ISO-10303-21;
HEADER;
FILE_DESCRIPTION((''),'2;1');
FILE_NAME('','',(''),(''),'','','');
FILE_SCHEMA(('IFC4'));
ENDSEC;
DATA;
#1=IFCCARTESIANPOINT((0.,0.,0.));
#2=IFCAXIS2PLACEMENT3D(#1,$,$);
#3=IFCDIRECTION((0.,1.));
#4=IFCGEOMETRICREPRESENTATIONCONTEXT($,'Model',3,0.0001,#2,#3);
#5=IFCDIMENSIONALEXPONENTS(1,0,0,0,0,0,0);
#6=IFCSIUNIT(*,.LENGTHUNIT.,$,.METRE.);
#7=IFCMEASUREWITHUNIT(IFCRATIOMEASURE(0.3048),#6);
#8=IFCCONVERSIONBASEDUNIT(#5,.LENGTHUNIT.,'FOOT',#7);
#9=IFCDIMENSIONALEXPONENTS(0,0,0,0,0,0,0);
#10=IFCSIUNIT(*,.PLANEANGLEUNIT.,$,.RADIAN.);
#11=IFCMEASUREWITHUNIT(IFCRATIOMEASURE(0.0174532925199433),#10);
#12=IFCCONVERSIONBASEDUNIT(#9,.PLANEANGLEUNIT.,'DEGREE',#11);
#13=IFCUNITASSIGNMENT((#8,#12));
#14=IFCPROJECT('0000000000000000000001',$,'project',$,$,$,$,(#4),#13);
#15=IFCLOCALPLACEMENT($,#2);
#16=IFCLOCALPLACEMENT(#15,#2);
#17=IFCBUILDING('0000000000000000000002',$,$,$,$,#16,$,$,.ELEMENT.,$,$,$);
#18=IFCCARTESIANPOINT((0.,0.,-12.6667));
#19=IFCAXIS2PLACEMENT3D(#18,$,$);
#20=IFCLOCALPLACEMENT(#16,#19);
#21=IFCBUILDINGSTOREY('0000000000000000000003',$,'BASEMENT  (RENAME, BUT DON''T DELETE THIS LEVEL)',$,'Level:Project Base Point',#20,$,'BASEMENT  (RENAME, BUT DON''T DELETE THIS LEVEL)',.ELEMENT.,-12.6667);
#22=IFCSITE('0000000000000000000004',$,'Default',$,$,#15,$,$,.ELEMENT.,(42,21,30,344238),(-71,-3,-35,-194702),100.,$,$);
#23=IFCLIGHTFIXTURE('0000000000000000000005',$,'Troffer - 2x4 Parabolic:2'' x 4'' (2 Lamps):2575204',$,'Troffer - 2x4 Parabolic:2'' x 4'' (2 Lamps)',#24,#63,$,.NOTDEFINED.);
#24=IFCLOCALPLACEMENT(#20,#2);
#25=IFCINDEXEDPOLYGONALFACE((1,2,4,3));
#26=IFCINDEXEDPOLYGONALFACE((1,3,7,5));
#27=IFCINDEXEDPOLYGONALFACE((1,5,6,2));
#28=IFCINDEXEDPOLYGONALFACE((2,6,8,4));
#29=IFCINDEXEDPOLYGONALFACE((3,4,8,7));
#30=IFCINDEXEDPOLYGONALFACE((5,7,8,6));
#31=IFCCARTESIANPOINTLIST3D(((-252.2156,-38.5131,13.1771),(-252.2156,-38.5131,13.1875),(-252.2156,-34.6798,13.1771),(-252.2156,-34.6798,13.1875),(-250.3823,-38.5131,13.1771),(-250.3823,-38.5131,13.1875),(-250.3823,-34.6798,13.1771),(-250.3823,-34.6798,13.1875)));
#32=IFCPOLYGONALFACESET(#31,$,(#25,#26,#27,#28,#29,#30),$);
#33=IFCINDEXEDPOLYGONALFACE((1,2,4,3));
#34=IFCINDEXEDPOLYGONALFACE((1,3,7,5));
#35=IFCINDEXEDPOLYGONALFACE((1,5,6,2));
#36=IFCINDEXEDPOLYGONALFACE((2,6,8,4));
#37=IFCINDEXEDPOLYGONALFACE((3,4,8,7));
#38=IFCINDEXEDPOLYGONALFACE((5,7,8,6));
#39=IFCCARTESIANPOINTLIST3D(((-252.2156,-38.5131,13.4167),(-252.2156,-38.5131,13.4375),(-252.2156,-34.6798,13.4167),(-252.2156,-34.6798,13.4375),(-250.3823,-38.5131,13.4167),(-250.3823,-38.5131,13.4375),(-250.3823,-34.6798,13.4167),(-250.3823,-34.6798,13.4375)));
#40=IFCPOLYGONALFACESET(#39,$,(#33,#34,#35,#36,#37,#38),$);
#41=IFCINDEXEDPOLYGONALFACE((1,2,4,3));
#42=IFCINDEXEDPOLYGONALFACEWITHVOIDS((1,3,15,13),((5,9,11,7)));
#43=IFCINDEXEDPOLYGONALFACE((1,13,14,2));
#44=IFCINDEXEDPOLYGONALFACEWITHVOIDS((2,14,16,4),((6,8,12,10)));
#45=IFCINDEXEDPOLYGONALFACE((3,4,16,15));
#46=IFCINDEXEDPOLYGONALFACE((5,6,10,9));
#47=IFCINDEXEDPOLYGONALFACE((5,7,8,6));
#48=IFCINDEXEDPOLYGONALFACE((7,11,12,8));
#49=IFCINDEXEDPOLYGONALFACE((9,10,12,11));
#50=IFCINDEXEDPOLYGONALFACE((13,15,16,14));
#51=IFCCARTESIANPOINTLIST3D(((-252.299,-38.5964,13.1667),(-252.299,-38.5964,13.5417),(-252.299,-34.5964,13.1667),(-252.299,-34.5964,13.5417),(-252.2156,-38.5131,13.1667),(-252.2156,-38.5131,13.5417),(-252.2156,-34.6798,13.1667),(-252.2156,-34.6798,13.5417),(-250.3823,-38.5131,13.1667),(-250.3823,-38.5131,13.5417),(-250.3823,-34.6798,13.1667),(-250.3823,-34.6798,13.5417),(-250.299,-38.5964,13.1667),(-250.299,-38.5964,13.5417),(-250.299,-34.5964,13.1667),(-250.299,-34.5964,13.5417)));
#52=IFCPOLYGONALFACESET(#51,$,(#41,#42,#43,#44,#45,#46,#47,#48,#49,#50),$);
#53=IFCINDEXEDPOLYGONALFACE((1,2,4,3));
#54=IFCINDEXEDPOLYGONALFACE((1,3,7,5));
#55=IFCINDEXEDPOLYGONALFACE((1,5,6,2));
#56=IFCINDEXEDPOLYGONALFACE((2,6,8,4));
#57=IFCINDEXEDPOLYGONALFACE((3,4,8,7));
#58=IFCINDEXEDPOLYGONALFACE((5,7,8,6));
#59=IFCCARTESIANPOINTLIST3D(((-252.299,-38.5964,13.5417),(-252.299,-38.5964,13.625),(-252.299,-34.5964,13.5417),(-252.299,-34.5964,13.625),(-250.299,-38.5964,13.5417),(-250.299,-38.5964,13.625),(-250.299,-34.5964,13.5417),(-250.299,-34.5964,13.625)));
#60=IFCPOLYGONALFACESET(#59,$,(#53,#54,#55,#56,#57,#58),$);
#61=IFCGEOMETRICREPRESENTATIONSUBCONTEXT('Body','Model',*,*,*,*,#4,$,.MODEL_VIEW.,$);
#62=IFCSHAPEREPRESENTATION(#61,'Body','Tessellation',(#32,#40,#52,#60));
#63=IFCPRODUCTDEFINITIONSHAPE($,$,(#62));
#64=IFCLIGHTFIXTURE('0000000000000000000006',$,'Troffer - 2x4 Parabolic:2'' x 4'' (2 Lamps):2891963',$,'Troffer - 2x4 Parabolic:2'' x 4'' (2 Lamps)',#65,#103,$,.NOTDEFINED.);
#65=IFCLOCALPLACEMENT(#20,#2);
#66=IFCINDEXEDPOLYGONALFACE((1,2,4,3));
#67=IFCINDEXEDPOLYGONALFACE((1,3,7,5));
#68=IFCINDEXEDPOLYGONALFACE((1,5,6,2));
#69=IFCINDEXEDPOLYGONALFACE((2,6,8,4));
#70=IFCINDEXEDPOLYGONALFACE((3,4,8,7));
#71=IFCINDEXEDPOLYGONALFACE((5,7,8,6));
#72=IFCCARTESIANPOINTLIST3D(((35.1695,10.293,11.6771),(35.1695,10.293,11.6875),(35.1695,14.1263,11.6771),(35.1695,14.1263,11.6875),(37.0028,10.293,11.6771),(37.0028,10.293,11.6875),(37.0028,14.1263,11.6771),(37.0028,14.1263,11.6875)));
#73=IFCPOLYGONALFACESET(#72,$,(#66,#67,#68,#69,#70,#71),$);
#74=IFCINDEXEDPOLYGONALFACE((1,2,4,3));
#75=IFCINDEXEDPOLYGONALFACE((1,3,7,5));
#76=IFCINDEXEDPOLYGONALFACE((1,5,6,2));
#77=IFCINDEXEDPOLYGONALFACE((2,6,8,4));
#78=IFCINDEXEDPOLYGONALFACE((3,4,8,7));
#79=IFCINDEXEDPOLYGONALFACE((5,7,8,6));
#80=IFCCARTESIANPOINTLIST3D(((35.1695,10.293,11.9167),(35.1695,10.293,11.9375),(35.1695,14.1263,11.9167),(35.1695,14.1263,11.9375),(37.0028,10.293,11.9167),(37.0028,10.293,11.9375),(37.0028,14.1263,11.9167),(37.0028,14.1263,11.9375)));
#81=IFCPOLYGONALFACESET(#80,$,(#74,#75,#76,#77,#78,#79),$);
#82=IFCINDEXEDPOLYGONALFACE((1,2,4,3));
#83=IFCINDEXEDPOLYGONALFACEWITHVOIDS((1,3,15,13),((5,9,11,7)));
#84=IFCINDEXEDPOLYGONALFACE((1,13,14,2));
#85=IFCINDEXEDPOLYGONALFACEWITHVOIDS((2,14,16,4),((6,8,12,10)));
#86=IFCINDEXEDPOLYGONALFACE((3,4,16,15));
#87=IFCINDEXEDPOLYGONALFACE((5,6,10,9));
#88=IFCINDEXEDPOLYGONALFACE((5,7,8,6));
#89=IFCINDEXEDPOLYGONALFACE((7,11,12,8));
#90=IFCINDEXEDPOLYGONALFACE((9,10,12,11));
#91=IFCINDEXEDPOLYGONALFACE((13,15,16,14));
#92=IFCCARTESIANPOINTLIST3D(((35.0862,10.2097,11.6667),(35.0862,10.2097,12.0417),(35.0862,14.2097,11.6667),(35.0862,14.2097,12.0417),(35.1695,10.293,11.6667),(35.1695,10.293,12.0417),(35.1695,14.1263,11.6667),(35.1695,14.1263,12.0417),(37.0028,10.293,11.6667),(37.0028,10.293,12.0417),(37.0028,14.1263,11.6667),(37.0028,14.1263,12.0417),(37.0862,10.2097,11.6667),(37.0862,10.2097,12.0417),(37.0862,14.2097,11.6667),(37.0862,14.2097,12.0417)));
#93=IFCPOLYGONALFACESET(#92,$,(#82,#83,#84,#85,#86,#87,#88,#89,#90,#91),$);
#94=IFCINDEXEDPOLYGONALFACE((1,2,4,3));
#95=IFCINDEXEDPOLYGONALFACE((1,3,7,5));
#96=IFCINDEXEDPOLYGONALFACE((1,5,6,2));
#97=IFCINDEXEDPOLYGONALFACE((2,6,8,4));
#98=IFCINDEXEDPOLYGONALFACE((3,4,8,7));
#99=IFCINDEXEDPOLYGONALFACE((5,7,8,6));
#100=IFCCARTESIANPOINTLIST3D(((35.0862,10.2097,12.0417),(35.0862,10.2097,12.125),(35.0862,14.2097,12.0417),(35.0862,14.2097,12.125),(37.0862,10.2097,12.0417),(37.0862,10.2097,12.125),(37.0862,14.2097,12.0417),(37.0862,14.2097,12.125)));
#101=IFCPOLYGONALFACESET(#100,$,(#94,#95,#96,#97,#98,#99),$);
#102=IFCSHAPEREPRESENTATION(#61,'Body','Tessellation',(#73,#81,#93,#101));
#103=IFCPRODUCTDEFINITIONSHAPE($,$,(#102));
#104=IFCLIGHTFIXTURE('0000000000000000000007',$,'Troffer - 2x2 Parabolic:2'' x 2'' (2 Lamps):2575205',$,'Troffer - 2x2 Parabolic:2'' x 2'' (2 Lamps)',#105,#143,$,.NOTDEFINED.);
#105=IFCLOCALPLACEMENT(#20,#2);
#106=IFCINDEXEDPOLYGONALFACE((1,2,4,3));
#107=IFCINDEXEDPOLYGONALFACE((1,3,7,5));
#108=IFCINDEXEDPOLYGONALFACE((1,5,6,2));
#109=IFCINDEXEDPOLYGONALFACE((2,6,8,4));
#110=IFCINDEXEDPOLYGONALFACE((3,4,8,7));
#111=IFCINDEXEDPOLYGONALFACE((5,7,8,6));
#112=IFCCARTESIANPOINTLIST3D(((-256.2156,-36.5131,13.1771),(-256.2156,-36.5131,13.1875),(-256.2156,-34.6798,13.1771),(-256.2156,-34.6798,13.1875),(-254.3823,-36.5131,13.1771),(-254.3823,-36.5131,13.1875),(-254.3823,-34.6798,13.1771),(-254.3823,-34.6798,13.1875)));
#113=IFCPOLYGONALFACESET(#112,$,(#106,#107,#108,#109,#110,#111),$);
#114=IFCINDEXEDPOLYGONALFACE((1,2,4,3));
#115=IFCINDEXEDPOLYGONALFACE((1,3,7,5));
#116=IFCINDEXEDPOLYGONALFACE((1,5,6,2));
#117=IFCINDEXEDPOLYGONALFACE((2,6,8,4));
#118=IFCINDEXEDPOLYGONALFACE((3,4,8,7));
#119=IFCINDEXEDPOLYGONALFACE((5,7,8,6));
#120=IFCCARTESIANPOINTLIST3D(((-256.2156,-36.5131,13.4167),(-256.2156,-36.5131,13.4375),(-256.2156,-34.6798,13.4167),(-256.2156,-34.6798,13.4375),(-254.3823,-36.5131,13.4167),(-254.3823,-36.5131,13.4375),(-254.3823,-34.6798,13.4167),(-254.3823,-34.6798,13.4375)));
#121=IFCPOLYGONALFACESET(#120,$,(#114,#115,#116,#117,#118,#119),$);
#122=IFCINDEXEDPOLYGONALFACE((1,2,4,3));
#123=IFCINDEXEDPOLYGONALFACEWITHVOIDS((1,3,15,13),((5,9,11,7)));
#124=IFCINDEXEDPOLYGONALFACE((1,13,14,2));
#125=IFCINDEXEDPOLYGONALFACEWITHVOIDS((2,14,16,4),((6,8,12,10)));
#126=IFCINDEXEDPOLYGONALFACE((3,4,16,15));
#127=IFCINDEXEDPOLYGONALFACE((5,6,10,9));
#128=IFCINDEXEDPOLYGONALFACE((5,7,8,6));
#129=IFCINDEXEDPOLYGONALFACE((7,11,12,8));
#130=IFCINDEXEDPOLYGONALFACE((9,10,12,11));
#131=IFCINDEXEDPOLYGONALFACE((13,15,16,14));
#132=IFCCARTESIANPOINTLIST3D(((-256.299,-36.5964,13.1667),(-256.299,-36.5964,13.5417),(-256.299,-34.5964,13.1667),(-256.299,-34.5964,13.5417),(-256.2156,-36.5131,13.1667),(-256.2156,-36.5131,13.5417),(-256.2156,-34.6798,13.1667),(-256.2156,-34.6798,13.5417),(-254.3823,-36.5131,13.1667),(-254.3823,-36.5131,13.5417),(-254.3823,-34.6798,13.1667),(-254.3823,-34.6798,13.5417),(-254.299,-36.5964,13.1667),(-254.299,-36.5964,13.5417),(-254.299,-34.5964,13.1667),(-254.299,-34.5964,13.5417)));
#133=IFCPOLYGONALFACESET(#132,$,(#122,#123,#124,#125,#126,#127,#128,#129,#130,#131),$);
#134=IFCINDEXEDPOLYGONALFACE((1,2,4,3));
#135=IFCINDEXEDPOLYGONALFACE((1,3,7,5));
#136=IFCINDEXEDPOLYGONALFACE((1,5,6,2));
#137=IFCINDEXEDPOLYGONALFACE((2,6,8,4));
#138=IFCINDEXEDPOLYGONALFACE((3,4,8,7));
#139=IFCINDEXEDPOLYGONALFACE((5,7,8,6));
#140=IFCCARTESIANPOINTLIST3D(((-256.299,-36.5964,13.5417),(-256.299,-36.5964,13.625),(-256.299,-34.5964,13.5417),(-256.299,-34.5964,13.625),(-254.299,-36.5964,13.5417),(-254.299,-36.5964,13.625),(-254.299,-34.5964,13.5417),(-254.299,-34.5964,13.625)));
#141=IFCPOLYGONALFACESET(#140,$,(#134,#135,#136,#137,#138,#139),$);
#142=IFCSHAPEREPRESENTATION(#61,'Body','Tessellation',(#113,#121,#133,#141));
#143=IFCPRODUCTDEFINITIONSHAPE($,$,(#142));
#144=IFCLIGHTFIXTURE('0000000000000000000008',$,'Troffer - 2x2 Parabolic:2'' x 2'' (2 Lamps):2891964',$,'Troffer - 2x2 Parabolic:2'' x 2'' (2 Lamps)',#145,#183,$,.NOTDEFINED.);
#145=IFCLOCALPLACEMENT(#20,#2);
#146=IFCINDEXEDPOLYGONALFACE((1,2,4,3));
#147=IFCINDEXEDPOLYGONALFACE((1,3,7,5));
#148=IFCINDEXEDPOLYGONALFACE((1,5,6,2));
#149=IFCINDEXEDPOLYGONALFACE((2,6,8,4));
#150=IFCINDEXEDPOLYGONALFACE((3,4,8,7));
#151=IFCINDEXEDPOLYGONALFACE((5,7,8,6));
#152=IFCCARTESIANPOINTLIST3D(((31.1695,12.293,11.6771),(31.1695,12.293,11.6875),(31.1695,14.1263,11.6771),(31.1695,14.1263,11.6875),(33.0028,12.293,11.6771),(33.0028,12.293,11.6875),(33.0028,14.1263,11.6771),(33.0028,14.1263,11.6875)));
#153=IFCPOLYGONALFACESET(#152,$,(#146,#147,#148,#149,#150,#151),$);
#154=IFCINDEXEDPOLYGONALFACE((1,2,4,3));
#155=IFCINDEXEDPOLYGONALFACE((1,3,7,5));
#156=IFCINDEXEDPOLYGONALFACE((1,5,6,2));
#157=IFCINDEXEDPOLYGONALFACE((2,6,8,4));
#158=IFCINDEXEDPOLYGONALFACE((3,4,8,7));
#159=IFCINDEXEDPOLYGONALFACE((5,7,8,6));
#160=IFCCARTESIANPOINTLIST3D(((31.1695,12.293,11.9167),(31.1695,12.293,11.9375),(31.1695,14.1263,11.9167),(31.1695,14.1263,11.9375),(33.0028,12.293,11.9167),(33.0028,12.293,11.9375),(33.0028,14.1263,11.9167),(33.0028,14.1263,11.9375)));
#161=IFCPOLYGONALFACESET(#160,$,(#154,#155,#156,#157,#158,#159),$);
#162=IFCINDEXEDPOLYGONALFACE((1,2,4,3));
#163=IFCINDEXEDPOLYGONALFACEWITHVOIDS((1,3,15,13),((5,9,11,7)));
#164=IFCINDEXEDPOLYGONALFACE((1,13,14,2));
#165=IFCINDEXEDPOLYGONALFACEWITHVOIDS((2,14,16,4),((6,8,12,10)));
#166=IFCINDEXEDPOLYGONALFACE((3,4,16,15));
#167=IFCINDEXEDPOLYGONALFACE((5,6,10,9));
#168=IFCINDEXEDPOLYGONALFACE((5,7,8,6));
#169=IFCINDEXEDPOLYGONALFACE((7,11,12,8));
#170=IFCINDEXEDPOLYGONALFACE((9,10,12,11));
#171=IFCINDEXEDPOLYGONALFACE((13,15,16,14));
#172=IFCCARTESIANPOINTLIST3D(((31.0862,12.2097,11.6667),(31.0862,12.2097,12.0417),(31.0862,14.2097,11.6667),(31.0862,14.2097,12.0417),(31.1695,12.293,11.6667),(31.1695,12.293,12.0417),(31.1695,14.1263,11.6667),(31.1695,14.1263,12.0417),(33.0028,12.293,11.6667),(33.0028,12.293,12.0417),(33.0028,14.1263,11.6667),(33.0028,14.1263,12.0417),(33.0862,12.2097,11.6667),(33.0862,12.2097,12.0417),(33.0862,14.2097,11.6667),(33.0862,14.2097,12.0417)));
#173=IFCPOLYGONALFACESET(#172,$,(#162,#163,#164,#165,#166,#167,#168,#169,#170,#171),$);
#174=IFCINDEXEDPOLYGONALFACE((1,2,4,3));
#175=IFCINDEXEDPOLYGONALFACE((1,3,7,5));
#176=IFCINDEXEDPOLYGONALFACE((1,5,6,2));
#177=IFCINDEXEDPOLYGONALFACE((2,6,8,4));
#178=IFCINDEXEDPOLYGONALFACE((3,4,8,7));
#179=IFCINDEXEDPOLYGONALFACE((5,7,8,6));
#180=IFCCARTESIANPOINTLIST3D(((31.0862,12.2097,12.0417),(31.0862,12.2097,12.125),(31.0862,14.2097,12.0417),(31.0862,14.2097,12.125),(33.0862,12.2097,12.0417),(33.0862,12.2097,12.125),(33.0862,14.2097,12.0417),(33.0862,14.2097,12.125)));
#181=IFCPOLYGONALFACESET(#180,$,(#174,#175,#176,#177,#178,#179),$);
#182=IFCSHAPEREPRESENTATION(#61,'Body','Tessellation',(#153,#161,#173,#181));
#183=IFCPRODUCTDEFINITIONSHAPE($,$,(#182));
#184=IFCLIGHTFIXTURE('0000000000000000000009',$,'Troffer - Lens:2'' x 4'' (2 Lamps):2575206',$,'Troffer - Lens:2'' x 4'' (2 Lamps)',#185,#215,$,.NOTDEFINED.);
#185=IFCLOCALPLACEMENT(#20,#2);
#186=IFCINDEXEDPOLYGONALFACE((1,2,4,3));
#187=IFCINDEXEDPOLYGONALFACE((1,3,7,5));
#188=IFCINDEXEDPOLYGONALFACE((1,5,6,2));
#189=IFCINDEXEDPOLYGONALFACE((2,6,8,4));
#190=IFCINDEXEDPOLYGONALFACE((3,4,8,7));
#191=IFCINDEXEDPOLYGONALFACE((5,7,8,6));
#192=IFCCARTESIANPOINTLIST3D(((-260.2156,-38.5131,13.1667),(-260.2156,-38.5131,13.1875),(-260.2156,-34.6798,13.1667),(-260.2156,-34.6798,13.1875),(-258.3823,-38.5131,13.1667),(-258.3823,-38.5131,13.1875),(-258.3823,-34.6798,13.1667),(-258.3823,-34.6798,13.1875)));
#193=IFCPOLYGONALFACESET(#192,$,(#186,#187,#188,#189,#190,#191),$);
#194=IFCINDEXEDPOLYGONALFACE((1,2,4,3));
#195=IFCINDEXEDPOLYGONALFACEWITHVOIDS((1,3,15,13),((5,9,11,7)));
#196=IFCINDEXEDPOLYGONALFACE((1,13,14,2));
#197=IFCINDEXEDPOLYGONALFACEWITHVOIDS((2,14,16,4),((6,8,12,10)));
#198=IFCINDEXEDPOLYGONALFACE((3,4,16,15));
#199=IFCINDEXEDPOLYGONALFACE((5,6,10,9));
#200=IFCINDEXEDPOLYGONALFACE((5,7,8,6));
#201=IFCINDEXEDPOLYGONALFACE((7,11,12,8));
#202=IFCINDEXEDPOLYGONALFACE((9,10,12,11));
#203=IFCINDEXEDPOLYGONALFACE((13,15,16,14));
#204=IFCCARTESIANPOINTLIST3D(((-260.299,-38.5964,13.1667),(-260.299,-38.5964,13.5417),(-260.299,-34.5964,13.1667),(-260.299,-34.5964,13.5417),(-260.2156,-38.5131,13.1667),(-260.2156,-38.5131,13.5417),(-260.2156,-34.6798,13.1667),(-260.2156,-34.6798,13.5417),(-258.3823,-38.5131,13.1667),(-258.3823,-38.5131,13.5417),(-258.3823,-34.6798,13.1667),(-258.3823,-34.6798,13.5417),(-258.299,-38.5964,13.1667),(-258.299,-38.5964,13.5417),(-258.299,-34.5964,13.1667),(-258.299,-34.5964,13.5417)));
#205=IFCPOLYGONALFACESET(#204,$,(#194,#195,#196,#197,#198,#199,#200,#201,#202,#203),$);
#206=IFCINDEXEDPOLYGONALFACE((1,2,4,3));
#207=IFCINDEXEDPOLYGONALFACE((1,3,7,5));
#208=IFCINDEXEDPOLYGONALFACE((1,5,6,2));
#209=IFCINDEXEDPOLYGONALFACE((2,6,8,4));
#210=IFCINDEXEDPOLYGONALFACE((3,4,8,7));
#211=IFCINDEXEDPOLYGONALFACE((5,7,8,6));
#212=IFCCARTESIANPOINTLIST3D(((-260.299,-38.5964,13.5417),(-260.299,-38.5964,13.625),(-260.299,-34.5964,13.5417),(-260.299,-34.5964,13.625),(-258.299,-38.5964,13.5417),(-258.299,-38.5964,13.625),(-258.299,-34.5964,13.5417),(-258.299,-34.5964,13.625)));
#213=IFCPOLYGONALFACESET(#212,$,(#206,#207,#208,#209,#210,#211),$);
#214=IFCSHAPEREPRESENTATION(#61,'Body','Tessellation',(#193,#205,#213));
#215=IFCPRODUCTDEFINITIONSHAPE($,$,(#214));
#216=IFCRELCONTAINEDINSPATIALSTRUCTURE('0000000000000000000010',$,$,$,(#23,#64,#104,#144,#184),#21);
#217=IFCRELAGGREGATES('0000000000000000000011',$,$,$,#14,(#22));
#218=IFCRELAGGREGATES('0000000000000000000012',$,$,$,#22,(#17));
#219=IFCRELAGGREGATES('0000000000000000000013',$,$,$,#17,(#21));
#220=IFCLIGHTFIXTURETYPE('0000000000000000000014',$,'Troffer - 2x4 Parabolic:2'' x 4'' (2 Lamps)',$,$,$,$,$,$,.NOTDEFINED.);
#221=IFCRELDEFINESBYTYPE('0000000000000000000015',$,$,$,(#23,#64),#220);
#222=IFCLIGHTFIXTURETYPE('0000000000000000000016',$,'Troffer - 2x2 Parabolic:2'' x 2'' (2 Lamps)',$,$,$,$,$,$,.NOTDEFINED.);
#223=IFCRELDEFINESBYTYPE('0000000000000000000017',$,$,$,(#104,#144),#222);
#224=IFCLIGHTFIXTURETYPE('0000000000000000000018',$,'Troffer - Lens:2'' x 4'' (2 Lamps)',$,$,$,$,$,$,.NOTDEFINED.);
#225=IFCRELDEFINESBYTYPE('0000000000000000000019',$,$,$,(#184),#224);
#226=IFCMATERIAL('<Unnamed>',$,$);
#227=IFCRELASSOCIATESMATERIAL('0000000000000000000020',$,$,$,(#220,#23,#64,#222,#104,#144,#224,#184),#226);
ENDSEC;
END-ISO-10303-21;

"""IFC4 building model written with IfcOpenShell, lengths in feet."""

from ifc_helpers import new_model, entity, si_unit, converted_unit, direction, frame, frame_2d, origin, origin_2d_with_axis, place, context, subcontext, project, spatial, polyline, rectangle, outline, extrude, source, transform, mapped, material, type_object, type_shapes, element, save


model = new_model("IFC4")

# Units and contexts
model_context = context("Model", 3, precision=0.0001, world=origin(), true_north=direction((0.0, 1.0)))
body_context = subcontext(model_context, "Body", "Model", "MODEL_VIEW")
ifc_project = project(units=[converted_unit("LENGTHUNIT", "FOOT", entity("IfcRatioMeasure", 0.3048), si_unit("LENGTHUNIT", "METRE"), dimensions=[1, 0, 0, 0, 0, 0, 0]), converted_unit("PLANEANGLEUNIT", "DEGREE", entity("IfcRatioMeasure", 0.0174532925199433), si_unit("PLANEANGLEUNIT", "RADIAN"), dimensions=[0, 0, 0, 0, 0, 0, 0])], contexts=[model_context])

# Site, building, storey
site_placement = place(None, origin())
site = spatial("IfcSite", under=ifc_project, at=site_placement, Name="Default", CompositionType="ELEMENT", RefLatitude=(42, 21, 30, 344238), RefLongitude=(-71, -3, -35, -194702), RefElevation=100.0)
building_placement = place(site_placement, origin())
building = spatial("IfcBuilding", under=site, at=building_placement, CompositionType="ELEMENT")
storey_placement = place(building_placement, frame((0.0, 0.0, -12.6667)))
storey = spatial("IfcBuildingStorey", under=building, at=storey_placement, Name="BASEMENT  (RENAME, BUT DON'T DELETE THIS LEVEL)", ObjectType="Level:Project Base Point", LongName="BASEMENT  (RENAME, BUT DON'T DELETE THIS LEVEL)", CompositionType="ELEMENT", Elevation=-12.6667)

# Light fixtures
ifc_material_1 = material(Name="<Unnamed>")
light_fixture_type_1 = type_object("IfcLightFixtureType", Name="Troffer - 2x4 Parabolic:2' x 4' (2 Lamps)", PredefinedType="NOTDEFINED", material=ifc_material_1)
shared_shape_1 = source(origin(), body_context, "Body", "SweptSolid", [
    extrude(rectangle(XDim=3.8333, YDim=1.8333, at=frame_2d((0.0, 0.0), x_axis=(1.0, 0.0))), frame((2.0, 1.0, 0.0104), z_axis=(0.0, 0.0, 1.0), x_axis=(-1.0, 0.0, 0.0)), (0.0, 0.0, 1.0), 0.0104),
    extrude(rectangle(XDim=3.8333, YDim=1.8333, at=origin_2d_with_axis()), frame((2.0, 1.0, 0.25), z_axis=(0.0, 0.0, 1.0), x_axis=(-1.0, 0.0, 0.0)), (0.0, 0.0, 1.0), 0.0208),
    extrude(outline(polyline([(-2.0, -1.0), (2.0, -1.0), (2.0, 1.0), (-2.0, 1.0), (-2.0, -1.0)]), holes=[polyline([(-1.9167, -0.9167), (-1.9167, 0.9167), (1.9167, 0.9167), (1.9167, -0.9167), (-1.9167, -0.9167)])]), frame((2.0, 1.0, 0.0), z_axis=(0.0, 0.0, 1.0), x_axis=(-1.0, 0.0, 0.0)), (0.0, 0.0, 1.0), 0.375),
    extrude(rectangle(XDim=4.0, YDim=2.0, at=frame_2d((0.0, 0.0), x_axis=(1.0, 0.0))), frame((2.0, 1.0, 0.375), z_axis=(0.0, 0.0, 1.0), x_axis=(-1.0, 0.0, 0.0)), (0.0, 0.0, 1.0), 0.0833),
])
type_shapes(light_fixture_type_1, [shared_shape_1])
for number, where, z_axis, x_axis, name in (
    (1, (-250.299, -38.5964, 13.1667), (0.0, 0.0, 1.0), (0.0, 1.0, 0.0), "Troffer - 2x4 Parabolic:2' x 4' (2 Lamps):2575204"),
    (2, (37.0862, 10.2097, 11.6667), (0.0, 0.0, 1.0), (0.0, 1.0, 0.0), "Troffer - 2x4 Parabolic:2' x 4' (2 Lamps):2891963"),
):
    element("IfcLightFixture", number, at=place(storey_placement, frame(where, z_axis=z_axis, x_axis=x_axis)), inside=storey, type_object=light_fixture_type_1, material=ifc_material_1, Name=name, ObjectType="Troffer - 2x4 Parabolic:2' x 4' (2 Lamps)", PredefinedType="NOTDEFINED", context=body_context, shape_type="MappedRepresentation", body=[
        mapped(shared_shape_1, transform((0.0, 0.0, 0.0), scale=1.0)),
    ])
light_fixture_type_2 = type_object("IfcLightFixtureType", Name="Troffer - 2x2 Parabolic:2' x 2' (2 Lamps)", PredefinedType="NOTDEFINED", material=ifc_material_1)
shared_shape_2 = source(origin(), body_context, "Body", "SweptSolid", [
    extrude(rectangle(XDim=1.8333, YDim=1.8333, at=origin_2d_with_axis()), frame((1.0, 1.0, 0.0104), z_axis=(0.0, 0.0, 1.0), x_axis=(-1.0, 0.0, 0.0)), (0.0, 0.0, 1.0), 0.0104),
    extrude(rectangle(XDim=1.8333, YDim=1.8333, at=origin_2d_with_axis()), frame((1.0, 1.0, 0.25), z_axis=(0.0, 0.0, 1.0), x_axis=(-1.0, 0.0, 0.0)), (0.0, 0.0, 1.0), 0.0208),
    extrude(outline(polyline([(-1.0, -1.0), (1.0, -1.0), (1.0, 1.0), (-1.0, 1.0), (-1.0, -1.0)]), holes=[polyline([(-0.9167, -0.9167), (-0.9167, 0.9167), (0.9167, 0.9167), (0.9167, -0.9167), (-0.9167, -0.9167)])]), frame((1.0, 1.0, 0.0), z_axis=(0.0, 0.0, 1.0), x_axis=(-1.0, 0.0, 0.0)), (0.0, 0.0, 1.0), 0.375),
    extrude(rectangle(XDim=2.0, YDim=2.0, at=origin_2d_with_axis()), frame((1.0, 1.0, 0.375), z_axis=(0.0, 0.0, 1.0), x_axis=(-1.0, 0.0, 0.0)), (0.0, 0.0, 1.0), 0.0833),
])
type_shapes(light_fixture_type_2, [shared_shape_2])
for number, where, name in (
    (3, (-256.299, -36.5964, 13.1667), "Troffer - 2x2 Parabolic:2' x 2' (2 Lamps):2575205"),
    (4, (31.0862, 12.2097, 11.6667), "Troffer - 2x2 Parabolic:2' x 2' (2 Lamps):2891964"),
):
    element("IfcLightFixture", number, at=place(storey_placement, frame(where)), inside=storey, type_object=light_fixture_type_2, material=ifc_material_1, Name=name, ObjectType="Troffer - 2x2 Parabolic:2' x 2' (2 Lamps)", PredefinedType="NOTDEFINED", context=body_context, shape_type="MappedRepresentation", body=[
        mapped(shared_shape_2, transform((0.0, 0.0, 0.0), scale=1.0)),
    ])
light_fixture_type_3 = type_object("IfcLightFixtureType", Name="Troffer - Lens:2' x 4' (2 Lamps)", PredefinedType="NOTDEFINED", material=ifc_material_1)
shared_shape_3 = source(origin(), body_context, "Body", "SweptSolid", [
    extrude(rectangle(XDim=3.8333, YDim=1.8333, at=origin_2d_with_axis()), frame((2.0, 1.0, 0.0), z_axis=(0.0, 0.0, 1.0), x_axis=(-1.0, 0.0, 0.0)), (0.0, 0.0, 1.0), 0.0208),
    extrude(outline(polyline([(-2.0, -1.0), (2.0, -1.0), (2.0, 1.0), (-2.0, 1.0), (-2.0, -1.0)]), holes=[polyline([(-1.9167, -0.9167), (-1.9167, 0.9167), (1.9167, 0.9167), (1.9167, -0.9167), (-1.9167, -0.9167)])]), frame((2.0, 1.0, 0.0), z_axis=(0.0, 0.0, 1.0), x_axis=(-1.0, 0.0, 0.0)), (0.0, 0.0, 1.0), 0.375),
    extrude(rectangle(XDim=4.0, YDim=2.0, at=frame_2d((0.0, 0.0), x_axis=(1.0, 0.0))), frame((2.0, 1.0, 0.375), z_axis=(0.0, 0.0, 1.0), x_axis=(-1.0, 0.0, 0.0)), (0.0, 0.0, 1.0), 0.0833),
])
type_shapes(light_fixture_type_3, [shared_shape_3])
for number, where, z_axis, x_axis, name in (
    (5, (-258.299, -38.5964, 13.1667), (0.0, 0.0, 1.0), (0.0, 1.0, 0.0), "Troffer - Lens:2' x 4' (2 Lamps):2575206"),
):
    element("IfcLightFixture", number, at=place(storey_placement, frame(where, z_axis=z_axis, x_axis=x_axis)), inside=storey, type_object=light_fixture_type_3, material=ifc_material_1, Name=name, ObjectType="Troffer - Lens:2' x 4' (2 Lamps)", PredefinedType="NOTDEFINED", context=body_context, shape_type="MappedRepresentation", body=[
        mapped(shared_shape_3, transform((0.0, 0.0, 0.0), scale=1.0)),
    ])

save(model, "model.ifc")
